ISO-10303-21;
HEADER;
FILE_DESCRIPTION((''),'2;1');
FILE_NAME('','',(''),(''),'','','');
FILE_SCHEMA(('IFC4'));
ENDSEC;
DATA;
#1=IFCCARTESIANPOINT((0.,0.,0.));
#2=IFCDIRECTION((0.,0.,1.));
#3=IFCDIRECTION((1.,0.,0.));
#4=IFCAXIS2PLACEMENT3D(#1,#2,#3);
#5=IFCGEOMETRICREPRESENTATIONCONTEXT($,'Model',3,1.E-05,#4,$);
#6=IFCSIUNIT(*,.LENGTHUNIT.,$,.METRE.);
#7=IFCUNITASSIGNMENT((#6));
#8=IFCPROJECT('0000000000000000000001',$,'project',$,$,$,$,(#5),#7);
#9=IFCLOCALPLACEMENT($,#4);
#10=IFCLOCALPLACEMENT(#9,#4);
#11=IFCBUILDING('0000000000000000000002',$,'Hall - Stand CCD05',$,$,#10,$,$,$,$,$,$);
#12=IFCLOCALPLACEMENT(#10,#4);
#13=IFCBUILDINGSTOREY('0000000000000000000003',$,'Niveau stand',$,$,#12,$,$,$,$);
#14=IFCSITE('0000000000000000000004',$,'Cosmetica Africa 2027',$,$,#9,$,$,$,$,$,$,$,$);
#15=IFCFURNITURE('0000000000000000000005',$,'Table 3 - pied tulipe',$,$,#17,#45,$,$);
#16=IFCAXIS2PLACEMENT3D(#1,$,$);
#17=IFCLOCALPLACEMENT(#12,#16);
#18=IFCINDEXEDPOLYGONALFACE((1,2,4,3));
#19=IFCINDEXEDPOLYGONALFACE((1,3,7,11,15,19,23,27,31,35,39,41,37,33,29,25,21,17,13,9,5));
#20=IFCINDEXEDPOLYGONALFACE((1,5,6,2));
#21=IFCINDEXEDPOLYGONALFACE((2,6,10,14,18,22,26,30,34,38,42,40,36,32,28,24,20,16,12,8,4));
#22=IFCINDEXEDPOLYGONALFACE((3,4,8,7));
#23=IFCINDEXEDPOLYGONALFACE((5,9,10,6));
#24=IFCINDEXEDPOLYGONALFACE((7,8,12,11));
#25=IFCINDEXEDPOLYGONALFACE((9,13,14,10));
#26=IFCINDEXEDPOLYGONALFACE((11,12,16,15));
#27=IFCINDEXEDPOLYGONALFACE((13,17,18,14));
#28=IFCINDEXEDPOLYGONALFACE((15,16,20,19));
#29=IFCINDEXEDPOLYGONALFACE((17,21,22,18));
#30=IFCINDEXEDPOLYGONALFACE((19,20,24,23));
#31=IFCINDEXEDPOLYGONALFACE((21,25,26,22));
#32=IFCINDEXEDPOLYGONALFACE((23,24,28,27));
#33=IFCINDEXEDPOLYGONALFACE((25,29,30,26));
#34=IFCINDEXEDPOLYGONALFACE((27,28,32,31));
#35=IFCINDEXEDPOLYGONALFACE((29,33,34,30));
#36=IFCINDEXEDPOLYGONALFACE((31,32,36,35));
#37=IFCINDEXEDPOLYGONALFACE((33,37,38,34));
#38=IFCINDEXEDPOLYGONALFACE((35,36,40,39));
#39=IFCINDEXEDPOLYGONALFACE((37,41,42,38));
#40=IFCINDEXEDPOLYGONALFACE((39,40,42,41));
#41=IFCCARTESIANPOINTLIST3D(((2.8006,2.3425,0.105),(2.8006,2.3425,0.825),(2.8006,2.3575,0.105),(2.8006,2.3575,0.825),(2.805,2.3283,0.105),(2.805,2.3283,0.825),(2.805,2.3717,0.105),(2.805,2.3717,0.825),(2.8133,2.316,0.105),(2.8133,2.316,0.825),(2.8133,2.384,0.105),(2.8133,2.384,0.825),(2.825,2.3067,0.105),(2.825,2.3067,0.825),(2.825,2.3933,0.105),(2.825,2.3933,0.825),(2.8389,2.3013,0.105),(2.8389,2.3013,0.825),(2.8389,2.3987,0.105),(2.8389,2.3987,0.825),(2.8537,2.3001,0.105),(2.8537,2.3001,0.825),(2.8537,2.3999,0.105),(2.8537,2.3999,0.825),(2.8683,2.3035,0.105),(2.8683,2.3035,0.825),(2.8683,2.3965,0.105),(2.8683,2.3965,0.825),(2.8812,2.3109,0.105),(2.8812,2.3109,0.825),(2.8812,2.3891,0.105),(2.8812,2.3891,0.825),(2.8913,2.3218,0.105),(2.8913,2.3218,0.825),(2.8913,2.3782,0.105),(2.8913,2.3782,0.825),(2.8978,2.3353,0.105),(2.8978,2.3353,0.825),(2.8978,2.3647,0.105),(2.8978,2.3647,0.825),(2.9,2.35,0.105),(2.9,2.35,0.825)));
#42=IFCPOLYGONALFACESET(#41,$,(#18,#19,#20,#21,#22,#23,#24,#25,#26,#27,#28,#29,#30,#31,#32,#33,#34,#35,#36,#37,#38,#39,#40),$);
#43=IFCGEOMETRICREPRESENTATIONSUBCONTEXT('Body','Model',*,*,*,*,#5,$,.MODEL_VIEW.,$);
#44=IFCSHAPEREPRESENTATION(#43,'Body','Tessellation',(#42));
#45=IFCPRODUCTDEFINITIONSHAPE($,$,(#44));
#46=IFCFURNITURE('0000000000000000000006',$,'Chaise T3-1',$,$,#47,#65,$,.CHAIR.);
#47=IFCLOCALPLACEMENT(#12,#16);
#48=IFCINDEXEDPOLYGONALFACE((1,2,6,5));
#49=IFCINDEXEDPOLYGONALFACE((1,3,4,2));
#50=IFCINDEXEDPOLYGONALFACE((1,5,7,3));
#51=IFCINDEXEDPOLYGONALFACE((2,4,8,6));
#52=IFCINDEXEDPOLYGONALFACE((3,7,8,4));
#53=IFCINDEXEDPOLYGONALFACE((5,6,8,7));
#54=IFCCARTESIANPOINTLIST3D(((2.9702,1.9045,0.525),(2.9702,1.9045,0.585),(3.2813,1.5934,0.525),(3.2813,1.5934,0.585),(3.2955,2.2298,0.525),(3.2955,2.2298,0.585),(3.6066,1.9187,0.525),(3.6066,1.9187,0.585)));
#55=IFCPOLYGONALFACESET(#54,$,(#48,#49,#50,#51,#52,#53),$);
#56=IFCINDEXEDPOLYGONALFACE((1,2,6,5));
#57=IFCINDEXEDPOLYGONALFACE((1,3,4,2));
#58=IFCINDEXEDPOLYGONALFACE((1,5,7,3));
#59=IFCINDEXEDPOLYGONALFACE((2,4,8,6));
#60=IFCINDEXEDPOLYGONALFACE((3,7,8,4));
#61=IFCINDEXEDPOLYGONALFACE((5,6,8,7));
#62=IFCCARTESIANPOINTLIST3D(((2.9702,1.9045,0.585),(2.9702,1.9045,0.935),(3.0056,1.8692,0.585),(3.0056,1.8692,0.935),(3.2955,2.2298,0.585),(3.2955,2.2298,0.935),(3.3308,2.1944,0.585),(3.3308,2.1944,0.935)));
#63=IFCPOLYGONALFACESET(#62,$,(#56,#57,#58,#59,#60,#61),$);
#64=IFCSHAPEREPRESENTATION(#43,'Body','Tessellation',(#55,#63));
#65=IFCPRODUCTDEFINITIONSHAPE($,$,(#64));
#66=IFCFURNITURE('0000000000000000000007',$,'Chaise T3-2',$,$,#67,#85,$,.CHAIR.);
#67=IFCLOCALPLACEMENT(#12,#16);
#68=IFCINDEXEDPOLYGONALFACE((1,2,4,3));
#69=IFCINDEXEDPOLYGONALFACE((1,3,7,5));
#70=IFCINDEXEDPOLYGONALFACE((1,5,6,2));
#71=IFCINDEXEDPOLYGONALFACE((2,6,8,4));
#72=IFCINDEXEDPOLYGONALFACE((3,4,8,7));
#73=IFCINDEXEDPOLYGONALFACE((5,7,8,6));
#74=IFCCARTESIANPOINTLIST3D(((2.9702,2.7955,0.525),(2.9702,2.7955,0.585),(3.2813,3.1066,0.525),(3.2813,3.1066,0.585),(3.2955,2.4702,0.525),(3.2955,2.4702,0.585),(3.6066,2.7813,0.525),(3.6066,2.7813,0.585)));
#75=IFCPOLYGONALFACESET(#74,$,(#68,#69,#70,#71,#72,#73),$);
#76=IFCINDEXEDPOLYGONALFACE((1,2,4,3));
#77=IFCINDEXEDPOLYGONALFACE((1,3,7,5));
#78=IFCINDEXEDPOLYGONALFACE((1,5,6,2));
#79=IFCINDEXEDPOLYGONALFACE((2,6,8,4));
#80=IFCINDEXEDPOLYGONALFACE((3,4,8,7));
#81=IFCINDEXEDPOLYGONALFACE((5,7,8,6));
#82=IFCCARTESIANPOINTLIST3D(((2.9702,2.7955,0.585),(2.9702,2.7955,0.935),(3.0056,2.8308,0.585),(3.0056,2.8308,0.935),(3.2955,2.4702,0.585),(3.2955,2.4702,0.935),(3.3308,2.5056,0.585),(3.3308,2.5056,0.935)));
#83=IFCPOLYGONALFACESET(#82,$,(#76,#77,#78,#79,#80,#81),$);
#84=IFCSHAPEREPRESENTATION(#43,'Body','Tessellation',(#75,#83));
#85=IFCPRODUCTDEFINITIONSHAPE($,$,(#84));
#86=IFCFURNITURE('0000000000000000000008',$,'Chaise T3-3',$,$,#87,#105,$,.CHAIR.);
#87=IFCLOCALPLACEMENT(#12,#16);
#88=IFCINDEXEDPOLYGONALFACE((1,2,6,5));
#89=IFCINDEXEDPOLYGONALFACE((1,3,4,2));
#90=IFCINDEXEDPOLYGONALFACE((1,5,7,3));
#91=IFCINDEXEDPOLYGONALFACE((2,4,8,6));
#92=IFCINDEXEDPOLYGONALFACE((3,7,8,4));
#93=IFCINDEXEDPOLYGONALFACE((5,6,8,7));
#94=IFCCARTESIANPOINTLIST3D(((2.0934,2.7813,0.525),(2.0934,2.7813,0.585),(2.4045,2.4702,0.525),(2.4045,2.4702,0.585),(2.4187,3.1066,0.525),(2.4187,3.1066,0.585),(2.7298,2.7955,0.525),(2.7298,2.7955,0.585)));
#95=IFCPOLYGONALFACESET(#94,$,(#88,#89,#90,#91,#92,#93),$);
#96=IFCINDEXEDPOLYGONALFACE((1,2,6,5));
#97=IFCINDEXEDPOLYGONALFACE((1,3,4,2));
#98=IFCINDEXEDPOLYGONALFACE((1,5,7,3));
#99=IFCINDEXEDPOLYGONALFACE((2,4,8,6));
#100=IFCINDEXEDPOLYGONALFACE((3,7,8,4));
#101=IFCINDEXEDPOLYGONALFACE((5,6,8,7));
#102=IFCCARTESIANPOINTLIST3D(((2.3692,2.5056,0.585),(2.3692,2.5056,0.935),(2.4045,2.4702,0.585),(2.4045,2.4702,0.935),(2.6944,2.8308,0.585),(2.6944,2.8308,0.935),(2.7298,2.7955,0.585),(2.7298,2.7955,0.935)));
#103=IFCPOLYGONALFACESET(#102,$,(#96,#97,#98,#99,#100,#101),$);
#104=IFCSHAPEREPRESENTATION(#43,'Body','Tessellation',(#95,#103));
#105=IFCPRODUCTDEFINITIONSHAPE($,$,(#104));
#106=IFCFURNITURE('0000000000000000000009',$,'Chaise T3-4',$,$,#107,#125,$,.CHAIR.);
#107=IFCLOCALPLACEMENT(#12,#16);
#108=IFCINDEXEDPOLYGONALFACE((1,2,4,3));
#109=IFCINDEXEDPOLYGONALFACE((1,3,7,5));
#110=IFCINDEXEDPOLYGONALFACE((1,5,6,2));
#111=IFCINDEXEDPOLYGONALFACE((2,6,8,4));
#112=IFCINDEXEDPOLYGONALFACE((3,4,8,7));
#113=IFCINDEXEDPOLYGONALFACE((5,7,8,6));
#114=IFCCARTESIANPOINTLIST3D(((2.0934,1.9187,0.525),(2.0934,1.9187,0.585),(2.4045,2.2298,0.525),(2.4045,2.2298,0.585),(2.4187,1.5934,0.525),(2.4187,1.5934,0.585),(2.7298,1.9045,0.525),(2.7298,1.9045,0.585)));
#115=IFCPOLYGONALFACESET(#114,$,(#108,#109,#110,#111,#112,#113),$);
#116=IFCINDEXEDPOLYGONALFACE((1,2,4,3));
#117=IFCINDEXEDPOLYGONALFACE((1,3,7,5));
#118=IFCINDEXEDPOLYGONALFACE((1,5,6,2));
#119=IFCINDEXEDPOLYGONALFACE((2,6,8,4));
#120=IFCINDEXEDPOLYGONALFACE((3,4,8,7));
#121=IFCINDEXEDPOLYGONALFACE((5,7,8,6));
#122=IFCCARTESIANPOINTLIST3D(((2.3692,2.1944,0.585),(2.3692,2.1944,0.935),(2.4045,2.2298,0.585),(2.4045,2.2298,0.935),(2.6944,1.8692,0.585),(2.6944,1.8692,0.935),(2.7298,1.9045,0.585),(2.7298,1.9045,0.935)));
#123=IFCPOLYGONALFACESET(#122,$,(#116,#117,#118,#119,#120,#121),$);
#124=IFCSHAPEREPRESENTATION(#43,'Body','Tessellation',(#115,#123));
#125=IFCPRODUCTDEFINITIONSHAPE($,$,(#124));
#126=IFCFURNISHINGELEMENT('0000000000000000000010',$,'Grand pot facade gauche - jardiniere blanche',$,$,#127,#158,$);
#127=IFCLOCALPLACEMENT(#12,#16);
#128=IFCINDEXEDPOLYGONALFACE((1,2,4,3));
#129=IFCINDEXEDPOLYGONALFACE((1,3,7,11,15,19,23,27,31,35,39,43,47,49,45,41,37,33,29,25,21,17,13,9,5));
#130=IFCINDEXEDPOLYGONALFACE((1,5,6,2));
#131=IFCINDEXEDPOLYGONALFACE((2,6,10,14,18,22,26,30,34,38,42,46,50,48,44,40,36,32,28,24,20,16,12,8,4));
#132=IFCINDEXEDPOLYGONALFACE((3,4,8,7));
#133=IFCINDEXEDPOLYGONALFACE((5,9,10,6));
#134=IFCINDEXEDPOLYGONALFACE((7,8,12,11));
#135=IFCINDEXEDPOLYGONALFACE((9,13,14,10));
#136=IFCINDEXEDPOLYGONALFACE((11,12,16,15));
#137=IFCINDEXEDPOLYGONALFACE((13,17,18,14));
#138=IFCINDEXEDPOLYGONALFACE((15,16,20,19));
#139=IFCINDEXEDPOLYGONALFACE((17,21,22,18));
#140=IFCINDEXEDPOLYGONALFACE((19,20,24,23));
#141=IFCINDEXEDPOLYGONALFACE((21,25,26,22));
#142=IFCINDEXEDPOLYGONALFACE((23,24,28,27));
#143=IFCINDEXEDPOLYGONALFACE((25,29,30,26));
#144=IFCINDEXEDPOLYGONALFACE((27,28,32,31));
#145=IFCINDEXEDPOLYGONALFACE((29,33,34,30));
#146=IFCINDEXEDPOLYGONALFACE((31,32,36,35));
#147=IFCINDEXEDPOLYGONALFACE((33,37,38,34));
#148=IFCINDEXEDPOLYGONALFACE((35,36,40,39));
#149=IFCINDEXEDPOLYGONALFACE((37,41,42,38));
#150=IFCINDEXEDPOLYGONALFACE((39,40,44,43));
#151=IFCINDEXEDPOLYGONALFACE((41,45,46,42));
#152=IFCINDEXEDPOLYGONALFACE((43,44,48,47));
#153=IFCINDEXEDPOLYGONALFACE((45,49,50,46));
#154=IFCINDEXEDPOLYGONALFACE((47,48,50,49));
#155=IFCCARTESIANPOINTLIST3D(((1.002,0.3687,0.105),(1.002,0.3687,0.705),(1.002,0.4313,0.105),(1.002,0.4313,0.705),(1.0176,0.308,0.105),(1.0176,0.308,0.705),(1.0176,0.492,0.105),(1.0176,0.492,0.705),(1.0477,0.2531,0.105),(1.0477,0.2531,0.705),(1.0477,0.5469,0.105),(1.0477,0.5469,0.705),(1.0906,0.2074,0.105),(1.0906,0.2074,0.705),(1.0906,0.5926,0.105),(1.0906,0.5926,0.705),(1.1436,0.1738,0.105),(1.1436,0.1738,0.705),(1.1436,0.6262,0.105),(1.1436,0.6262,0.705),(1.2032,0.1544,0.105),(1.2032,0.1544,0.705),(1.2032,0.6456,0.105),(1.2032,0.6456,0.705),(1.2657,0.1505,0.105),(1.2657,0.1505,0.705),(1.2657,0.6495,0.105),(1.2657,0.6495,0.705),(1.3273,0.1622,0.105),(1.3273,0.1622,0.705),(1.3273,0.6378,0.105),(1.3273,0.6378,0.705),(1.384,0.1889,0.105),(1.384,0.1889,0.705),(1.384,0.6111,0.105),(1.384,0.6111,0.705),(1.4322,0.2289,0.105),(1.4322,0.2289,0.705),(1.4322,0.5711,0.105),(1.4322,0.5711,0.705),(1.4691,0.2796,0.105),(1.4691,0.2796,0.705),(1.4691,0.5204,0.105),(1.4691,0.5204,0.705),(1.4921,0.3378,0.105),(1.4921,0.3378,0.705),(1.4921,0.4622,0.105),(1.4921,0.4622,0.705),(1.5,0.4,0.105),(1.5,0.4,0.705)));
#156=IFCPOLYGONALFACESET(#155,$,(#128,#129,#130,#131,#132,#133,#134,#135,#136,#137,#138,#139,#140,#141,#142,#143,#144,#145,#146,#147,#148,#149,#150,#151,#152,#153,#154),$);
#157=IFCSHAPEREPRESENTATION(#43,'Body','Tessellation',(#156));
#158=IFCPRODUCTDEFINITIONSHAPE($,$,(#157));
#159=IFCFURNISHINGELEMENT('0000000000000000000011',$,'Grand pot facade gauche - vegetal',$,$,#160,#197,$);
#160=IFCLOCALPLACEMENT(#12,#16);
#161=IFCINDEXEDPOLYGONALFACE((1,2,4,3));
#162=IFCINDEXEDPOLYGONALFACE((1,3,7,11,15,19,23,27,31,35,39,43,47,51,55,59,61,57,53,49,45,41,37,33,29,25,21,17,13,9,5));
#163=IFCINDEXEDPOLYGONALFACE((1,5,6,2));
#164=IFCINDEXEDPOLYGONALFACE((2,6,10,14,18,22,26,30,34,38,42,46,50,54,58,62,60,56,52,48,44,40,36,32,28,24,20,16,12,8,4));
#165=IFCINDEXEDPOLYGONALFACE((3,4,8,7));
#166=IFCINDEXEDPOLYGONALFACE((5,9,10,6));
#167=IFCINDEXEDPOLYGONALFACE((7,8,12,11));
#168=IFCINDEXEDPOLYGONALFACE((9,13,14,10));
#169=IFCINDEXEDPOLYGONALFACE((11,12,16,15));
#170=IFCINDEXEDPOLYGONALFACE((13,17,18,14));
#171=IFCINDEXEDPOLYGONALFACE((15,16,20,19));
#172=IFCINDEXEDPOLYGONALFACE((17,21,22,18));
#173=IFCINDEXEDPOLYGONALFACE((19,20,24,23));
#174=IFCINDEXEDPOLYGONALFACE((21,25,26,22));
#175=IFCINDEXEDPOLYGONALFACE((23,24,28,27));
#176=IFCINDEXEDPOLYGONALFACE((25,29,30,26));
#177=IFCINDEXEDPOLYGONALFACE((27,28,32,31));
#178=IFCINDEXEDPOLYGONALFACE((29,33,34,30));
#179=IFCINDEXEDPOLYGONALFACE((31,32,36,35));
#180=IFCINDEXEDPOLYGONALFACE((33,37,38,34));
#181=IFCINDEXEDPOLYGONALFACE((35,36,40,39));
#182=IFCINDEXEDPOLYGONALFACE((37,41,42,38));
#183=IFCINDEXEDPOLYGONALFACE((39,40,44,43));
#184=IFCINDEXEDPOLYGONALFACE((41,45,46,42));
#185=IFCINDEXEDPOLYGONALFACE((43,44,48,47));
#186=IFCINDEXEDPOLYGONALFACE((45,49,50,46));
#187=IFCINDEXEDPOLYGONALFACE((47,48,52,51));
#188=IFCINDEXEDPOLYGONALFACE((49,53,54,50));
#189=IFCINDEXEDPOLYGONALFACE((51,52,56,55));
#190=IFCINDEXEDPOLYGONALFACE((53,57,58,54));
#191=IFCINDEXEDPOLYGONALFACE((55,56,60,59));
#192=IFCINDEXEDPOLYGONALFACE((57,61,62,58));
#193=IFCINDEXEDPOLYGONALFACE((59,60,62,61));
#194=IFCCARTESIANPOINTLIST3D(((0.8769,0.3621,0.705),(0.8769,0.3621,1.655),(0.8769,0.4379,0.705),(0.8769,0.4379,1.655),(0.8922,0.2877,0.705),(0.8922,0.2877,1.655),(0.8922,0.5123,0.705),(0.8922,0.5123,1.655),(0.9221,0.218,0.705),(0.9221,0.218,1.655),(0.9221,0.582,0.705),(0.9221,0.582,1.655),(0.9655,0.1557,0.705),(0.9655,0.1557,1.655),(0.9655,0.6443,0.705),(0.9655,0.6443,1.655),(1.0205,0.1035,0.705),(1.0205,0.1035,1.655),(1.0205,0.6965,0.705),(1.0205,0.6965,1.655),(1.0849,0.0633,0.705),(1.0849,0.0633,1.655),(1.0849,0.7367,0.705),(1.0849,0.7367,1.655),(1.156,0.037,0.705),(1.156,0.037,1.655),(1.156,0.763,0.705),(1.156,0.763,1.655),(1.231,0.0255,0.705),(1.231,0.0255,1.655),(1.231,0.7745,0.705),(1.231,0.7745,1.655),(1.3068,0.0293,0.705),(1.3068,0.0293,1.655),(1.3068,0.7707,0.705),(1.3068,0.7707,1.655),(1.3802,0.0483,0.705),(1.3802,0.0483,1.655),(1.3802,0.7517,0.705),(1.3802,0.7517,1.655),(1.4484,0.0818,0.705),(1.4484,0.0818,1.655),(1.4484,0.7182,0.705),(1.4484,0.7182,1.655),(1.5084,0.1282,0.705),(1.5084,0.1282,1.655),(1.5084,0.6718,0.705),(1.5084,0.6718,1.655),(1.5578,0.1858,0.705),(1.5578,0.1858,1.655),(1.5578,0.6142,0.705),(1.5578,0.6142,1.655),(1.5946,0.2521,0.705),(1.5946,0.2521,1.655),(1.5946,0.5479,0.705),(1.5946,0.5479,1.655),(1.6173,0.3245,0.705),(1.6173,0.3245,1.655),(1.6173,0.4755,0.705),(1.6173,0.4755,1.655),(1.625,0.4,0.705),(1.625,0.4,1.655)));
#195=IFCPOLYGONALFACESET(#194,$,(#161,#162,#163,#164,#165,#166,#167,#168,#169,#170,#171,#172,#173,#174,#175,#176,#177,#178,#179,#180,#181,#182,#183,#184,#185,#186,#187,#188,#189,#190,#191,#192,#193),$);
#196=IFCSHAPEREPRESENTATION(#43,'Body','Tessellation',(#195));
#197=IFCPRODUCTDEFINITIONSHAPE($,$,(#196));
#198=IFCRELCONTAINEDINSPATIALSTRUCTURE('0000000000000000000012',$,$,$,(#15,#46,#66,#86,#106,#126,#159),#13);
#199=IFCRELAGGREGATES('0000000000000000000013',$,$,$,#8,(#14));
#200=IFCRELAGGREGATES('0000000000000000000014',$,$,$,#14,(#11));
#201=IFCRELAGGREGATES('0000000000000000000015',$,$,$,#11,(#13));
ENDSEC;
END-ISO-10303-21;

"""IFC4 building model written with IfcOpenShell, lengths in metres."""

from ifc_helpers import new_model, si_unit, frame, frame_2d, origin_with_axes, place, context, subcontext, project, spatial, polyline, circle, outline, extrude, element, save


model = new_model("IFC4")

# Units and contexts
model_context = context("Model", 3, precision=1e-05, world=origin_with_axes())
body_context = subcontext(model_context, "Body", "Model", "MODEL_VIEW")
ifc_project = project(units=[si_unit("LENGTHUNIT", "METRE")], contexts=[model_context])

# Site, building, storey
site_placement = place(None, origin_with_axes())
site = spatial("IfcSite", under=ifc_project, at=site_placement, Name="Cosmetica Africa 2027")
building_placement = place(site_placement, origin_with_axes())
building = spatial("IfcBuilding", under=site, at=building_placement, Name="Hall - Stand CCD05")
storey_placement = place(building_placement, origin_with_axes())
storey = spatial("IfcBuildingStorey", under=building, at=storey_placement, Name="Niveau stand")

# Furniture
furniture_1_placement = place(storey_placement, origin_with_axes())
element("IfcFurniture", 1, at=furniture_1_placement, inside=storey, Name="Table 3 - pied tulipe", context=body_context, shape_type="SweptSolid", body=[
    extrude(circle(Radius=0.05, at=frame_2d((2.85, 2.35))), frame((0.0, 0.0, 0.105)), (0.0, 0.0, 1.0), 0.72),
])
furniture_2_placement = place(storey_placement, origin_with_axes())
element("IfcFurniture", 2, at=furniture_2_placement, inside=storey, Name="Chaise T3-1", PredefinedType="CHAIR", context=body_context, shape_type="SweptSolid", body=[
    extrude(outline(polyline([(3.2813, 1.5934), (3.6066, 1.9187), (3.2955, 2.2298), (2.9702, 1.9045), (3.2813, 1.5934)])), frame((0.0, 0.0, 0.525)), (0.0, 0.0, 1.0), 0.06),
    extrude(outline(polyline([(3.0056, 1.8692), (3.3308, 2.1944), (3.2955, 2.2298), (2.9702, 1.9045), (3.0056, 1.8692)])), frame((0.0, 0.0, 0.585)), (0.0, 0.0, 1.0), 0.35),
])
furniture_3_placement = place(storey_placement, origin_with_axes())
element("IfcFurniture", 3, at=furniture_3_placement, inside=storey, Name="Chaise T3-2", PredefinedType="CHAIR", context=body_context, shape_type="SweptSolid", body=[
    extrude(outline(polyline([(3.6066, 2.7813), (3.2813, 3.1066), (2.9702, 2.7955), (3.2955, 2.4702), (3.6066, 2.7813)])), frame((0.0, 0.0, 0.525)), (0.0, 0.0, 1.0), 0.06),
    extrude(outline(polyline([(3.3308, 2.5056), (3.0056, 2.8308), (2.9702, 2.7955), (3.2955, 2.4702), (3.3308, 2.5056)])), frame((0.0, 0.0, 0.585)), (0.0, 0.0, 1.0), 0.35),
])
furniture_4_placement = place(storey_placement, origin_with_axes())
element("IfcFurniture", 4, at=furniture_4_placement, inside=storey, Name="Chaise T3-3", PredefinedType="CHAIR", context=body_context, shape_type="SweptSolid", body=[
    extrude(outline(polyline([(2.4187, 3.1066), (2.0934, 2.7813), (2.4045, 2.4702), (2.7298, 2.7955), (2.4187, 3.1066)])), frame((0.0, 0.0, 0.525)), (0.0, 0.0, 1.0), 0.06),
    extrude(outline(polyline([(2.6944, 2.8308), (2.3692, 2.5056), (2.4045, 2.4702), (2.7298, 2.7955), (2.6944, 2.8308)])), frame((0.0, 0.0, 0.585)), (0.0, 0.0, 1.0), 0.35),
])
furniture_5_placement = place(storey_placement, origin_with_axes())
element("IfcFurniture", 5, at=furniture_5_placement, inside=storey, Name="Chaise T3-4", PredefinedType="CHAIR", context=body_context, shape_type="SweptSolid", body=[
    extrude(outline(polyline([(2.0934, 1.9187), (2.4187, 1.5934), (2.7298, 1.9045), (2.4045, 2.2298), (2.0934, 1.9187)])), frame((0.0, 0.0, 0.525)), (0.0, 0.0, 1.0), 0.06),
    extrude(outline(polyline([(2.3692, 2.1944), (2.6944, 1.8692), (2.7298, 1.9045), (2.4045, 2.2298), (2.3692, 2.1944)])), frame((0.0, 0.0, 0.585)), (0.0, 0.0, 1.0), 0.35),
])

# Furnishing elements
furnishing_1_placement = place(storey_placement, origin_with_axes())
element("IfcFurnishingElement", 6, at=furnishing_1_placement, inside=storey, Name="Grand pot facade gauche - jardiniere blanche", context=body_context, shape_type="SweptSolid", body=[
    extrude(circle(Radius=0.25, at=frame_2d((1.25, 0.4))), frame((0.0, 0.0, 0.105)), (0.0, 0.0, 1.0), 0.6),
])
furnishing_2_placement = place(storey_placement, origin_with_axes())
element("IfcFurnishingElement", 7, at=furnishing_2_placement, inside=storey, Name="Grand pot facade gauche - vegetal", context=body_context, shape_type="SweptSolid", body=[
    extrude(circle(Radius=0.375, at=frame_2d((1.25, 0.4))), frame((0.0, 0.0, 0.705)), (0.0, 0.0, 1.0), 0.95),
])

save(model, "model.ifc")
